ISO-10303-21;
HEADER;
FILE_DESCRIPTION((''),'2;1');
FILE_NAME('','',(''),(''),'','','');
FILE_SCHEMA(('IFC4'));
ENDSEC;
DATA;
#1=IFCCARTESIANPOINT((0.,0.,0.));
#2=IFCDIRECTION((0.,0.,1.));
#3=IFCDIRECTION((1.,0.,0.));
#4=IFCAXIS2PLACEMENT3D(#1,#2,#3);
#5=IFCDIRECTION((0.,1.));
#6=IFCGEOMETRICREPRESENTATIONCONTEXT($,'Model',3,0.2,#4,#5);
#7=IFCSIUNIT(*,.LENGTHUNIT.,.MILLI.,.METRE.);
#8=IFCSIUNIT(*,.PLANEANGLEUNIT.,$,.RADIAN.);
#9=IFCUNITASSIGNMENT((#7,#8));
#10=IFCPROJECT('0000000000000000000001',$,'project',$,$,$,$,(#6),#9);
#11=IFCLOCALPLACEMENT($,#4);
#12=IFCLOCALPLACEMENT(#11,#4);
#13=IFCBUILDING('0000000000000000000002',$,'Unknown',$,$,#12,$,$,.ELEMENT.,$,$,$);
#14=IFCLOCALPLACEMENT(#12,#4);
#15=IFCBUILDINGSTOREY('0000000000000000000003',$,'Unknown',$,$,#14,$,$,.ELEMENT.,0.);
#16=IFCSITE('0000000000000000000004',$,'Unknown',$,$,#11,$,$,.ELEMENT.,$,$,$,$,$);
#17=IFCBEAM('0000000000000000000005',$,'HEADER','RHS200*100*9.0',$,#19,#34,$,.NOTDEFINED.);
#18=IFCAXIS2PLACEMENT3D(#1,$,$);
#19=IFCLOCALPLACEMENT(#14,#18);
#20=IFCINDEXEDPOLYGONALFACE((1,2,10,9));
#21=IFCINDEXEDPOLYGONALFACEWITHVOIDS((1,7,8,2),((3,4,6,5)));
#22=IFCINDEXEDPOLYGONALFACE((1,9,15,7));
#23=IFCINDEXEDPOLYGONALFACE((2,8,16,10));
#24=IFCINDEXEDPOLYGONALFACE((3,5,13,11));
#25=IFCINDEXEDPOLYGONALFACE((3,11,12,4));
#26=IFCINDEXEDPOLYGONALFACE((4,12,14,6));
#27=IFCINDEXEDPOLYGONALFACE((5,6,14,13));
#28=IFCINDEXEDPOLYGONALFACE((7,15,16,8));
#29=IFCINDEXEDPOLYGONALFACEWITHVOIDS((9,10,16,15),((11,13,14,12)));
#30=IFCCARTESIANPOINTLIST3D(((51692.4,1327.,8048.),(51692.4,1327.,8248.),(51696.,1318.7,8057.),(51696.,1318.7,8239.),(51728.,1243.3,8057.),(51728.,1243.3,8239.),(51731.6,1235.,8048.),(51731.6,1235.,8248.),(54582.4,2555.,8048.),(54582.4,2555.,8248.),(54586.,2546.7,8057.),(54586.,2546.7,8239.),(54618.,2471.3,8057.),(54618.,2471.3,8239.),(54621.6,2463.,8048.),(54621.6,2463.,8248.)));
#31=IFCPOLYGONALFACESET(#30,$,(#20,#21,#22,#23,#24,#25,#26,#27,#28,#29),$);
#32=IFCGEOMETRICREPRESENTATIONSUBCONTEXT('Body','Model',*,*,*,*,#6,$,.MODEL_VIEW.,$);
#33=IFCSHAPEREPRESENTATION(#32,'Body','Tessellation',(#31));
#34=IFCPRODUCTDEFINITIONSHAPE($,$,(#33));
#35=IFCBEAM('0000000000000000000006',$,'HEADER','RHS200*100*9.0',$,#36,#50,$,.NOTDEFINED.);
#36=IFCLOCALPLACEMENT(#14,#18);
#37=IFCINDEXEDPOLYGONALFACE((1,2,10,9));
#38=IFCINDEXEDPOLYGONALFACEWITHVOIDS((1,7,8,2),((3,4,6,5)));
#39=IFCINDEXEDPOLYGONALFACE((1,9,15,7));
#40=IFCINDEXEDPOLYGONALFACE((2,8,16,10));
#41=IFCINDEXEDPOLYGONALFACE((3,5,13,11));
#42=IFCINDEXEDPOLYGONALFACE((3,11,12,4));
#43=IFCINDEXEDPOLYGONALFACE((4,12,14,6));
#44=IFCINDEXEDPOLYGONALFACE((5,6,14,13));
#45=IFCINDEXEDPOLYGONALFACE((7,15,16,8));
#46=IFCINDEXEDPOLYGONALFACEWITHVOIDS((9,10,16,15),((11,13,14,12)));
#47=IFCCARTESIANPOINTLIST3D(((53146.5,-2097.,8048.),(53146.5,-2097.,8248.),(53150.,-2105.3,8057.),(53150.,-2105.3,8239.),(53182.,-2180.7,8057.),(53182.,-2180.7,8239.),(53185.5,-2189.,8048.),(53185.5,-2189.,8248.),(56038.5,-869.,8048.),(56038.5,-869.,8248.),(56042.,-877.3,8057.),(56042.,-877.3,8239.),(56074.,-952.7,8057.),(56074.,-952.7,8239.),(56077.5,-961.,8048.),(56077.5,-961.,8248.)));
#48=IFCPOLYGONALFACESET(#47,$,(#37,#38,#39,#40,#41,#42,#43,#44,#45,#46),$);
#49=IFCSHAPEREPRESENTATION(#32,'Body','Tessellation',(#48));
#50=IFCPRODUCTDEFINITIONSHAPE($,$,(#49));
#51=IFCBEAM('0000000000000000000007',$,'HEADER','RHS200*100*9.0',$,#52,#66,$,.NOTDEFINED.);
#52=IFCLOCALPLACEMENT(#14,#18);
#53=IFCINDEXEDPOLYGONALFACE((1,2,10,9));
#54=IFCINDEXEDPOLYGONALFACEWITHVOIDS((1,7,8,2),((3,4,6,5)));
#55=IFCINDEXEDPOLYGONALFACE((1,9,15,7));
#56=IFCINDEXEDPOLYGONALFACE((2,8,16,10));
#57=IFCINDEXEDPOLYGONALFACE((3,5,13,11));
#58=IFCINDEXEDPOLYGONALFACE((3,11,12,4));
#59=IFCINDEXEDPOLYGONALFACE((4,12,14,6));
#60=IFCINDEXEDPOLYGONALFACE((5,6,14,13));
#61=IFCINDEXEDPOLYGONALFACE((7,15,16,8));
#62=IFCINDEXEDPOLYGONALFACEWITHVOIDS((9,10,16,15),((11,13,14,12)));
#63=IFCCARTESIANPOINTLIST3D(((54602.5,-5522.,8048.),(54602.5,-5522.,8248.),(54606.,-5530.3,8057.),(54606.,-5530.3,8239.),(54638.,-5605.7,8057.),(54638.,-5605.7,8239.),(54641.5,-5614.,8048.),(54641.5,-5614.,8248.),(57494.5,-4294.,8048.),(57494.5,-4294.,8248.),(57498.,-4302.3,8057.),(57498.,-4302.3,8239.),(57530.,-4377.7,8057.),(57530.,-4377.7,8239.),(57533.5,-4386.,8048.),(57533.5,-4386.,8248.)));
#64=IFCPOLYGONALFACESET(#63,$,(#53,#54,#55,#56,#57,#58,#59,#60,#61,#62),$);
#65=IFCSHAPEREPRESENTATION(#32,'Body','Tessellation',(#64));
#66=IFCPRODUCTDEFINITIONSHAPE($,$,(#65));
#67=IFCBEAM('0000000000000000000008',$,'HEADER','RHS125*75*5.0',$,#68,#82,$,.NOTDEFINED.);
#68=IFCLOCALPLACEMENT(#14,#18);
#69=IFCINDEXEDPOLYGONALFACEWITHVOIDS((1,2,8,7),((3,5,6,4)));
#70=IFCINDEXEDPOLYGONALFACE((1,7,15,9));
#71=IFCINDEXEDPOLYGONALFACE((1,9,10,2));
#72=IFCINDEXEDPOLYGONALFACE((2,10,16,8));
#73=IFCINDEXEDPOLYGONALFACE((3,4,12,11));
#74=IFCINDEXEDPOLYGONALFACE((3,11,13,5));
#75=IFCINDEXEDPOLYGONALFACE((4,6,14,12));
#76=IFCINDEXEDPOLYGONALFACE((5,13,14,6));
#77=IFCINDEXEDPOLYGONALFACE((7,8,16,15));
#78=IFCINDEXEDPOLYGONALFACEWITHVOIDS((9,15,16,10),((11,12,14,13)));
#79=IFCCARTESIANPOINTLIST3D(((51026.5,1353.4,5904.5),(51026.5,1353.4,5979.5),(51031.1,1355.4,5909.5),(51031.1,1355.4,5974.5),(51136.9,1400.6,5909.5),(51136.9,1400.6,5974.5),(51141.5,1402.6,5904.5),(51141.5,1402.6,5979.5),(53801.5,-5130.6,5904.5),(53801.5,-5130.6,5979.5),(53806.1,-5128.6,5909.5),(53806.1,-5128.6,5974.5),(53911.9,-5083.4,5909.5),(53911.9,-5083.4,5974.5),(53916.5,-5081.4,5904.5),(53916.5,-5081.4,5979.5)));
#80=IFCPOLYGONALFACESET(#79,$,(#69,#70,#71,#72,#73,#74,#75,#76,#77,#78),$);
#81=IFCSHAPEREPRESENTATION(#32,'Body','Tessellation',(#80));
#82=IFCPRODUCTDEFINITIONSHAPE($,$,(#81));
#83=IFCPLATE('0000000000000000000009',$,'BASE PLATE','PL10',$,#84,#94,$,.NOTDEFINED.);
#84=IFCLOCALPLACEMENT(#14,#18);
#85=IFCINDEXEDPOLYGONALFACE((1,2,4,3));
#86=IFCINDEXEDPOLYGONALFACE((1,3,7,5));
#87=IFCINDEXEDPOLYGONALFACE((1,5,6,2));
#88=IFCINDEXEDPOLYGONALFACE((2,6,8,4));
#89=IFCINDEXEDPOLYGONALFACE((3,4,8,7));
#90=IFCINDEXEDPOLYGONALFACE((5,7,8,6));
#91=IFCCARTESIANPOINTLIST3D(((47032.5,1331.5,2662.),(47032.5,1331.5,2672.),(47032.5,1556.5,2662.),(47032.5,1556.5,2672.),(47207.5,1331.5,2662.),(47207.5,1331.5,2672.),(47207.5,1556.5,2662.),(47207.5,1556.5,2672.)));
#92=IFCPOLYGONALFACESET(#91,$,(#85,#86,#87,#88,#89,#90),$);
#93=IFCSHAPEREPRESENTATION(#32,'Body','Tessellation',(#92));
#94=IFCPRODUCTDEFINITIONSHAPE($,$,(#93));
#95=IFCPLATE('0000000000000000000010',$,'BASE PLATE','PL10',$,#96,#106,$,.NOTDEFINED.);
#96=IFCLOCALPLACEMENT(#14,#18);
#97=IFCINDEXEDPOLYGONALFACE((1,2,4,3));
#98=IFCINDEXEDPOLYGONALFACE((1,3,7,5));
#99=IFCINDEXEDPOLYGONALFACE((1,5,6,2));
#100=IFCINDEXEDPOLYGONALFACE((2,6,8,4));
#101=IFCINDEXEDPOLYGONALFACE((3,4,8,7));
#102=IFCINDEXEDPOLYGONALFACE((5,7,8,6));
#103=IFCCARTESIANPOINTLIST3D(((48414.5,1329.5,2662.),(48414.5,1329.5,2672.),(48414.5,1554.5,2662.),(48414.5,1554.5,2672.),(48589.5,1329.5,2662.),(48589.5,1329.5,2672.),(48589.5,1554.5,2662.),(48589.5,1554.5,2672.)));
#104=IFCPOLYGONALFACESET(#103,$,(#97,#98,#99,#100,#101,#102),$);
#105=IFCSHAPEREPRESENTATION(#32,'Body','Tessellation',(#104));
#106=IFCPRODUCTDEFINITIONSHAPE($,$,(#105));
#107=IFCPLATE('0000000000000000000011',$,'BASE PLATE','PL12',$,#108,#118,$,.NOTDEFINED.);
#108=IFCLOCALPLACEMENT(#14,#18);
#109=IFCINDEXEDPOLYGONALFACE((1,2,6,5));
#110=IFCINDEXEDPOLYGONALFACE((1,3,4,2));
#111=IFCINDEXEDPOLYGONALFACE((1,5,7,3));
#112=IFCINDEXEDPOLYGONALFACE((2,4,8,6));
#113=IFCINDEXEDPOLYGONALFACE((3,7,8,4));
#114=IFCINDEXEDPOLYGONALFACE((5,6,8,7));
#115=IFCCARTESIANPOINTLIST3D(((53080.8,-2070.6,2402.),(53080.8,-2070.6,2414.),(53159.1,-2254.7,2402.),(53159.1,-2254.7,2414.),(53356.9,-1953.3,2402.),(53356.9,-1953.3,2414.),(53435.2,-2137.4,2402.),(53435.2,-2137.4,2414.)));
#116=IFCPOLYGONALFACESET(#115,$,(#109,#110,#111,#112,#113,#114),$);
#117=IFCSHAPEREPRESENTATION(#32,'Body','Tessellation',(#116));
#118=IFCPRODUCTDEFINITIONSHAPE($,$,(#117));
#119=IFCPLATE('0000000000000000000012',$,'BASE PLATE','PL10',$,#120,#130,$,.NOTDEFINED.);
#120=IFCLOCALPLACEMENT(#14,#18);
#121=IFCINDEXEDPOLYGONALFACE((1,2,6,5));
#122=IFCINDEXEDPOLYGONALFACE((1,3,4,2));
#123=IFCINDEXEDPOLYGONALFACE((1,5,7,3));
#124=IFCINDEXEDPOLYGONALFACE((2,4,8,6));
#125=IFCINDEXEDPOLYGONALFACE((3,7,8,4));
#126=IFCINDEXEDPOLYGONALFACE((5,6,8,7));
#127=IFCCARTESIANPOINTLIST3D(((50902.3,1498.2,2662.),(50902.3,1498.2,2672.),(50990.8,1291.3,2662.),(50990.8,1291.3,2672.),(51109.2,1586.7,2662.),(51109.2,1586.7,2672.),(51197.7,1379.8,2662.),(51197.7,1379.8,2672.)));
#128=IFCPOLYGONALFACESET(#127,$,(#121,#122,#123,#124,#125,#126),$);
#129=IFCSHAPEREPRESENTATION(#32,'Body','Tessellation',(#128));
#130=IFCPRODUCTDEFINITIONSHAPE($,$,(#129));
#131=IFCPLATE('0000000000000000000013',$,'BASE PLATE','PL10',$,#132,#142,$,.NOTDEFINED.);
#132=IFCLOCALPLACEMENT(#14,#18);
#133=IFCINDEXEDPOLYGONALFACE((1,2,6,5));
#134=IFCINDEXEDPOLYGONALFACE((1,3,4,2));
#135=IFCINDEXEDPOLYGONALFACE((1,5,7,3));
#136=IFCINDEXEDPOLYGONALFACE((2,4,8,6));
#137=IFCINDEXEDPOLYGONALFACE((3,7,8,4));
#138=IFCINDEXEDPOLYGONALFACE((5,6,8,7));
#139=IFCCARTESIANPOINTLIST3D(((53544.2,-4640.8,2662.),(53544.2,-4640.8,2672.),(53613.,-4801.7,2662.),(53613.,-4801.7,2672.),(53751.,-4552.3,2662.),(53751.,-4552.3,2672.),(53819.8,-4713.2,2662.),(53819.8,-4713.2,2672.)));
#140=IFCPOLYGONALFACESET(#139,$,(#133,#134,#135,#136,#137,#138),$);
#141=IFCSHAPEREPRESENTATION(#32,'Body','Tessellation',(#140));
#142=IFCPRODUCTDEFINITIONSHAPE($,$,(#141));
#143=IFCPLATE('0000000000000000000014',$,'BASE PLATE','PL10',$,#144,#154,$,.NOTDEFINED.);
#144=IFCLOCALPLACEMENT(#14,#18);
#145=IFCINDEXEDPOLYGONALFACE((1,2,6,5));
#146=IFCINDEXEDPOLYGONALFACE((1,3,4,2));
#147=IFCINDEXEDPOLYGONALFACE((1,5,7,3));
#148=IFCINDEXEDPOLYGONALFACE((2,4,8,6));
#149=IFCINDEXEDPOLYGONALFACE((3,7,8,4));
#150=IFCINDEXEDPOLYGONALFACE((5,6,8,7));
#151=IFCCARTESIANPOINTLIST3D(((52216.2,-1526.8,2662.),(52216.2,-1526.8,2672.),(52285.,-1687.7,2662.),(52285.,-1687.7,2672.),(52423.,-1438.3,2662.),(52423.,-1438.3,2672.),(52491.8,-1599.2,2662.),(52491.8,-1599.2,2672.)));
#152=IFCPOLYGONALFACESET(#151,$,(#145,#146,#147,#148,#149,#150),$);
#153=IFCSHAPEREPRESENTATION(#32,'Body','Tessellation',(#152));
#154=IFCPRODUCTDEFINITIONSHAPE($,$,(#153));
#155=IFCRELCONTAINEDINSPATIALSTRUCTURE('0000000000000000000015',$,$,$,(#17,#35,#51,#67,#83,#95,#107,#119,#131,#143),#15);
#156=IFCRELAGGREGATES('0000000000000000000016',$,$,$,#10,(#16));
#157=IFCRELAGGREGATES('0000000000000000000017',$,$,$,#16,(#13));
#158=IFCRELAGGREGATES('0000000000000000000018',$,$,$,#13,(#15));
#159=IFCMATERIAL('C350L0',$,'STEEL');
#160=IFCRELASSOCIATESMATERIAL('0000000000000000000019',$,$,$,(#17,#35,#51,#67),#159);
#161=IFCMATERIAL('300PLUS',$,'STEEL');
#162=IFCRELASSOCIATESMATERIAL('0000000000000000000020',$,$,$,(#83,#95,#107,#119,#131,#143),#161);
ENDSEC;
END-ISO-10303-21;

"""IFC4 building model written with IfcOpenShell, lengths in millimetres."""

from ifc_helpers import new_model, si_unit, direction, frame, origin_with_axes, place, context, subcontext, project, spatial, line, indexed_curve, outline, extrude, material, element, save


model = new_model("IFC4")

# Units and contexts
model_context = context("Model", 3, precision=0.2, world=origin_with_axes(), true_north=direction((0.0, 1.0)))
body_context = subcontext(model_context, "Body", "Model", "MODEL_VIEW")
ifc_project = project(units=[si_unit("LENGTHUNIT", "METRE", prefix="MILLI"), si_unit("PLANEANGLEUNIT", "RADIAN")], contexts=[model_context])

# Site, building, storey
site_placement = place(None, origin_with_axes())
site = spatial("IfcSite", under=ifc_project, at=site_placement, Name="Unknown", CompositionType="ELEMENT")
building_placement = place(site_placement, origin_with_axes())
building = spatial("IfcBuilding", under=site, at=building_placement, Name="Unknown", CompositionType="ELEMENT")
storey_placement = place(building_placement, origin_with_axes())
storey = spatial("IfcBuildingStorey", under=building, at=storey_placement, Name="Unknown", CompositionType="ELEMENT", Elevation=0.0)

# Shared definitions
ifc_material_1 = material(Name="C350L0", Category="STEEL")

# Beams
beam_1_placement = place(storey_placement, frame((51712.0, 1281.0, 8148.0), z_axis=(0.391073, -0.92036, 0.0), x_axis=(0.92036, 0.391073, 0.0)))
element("IfcBeam", 1, at=beam_1_placement, inside=storey, material=ifc_material_1, Name="HEADER", Description="RHS200*100*9.0", PredefinedType="NOTDEFINED", context=body_context, shape_type="SolidModel", body=[
    extrude(outline(indexed_curve([(-50.0, -100.0), (50.0, -100.0), (50.0, 100.0), (-50.0, 100.0)], segments=[line(1, 2, 3, 4, 1)]), holes=[indexed_curve([(-41.0, -91.0), (-41.0, 91.0), (41.0, 91.0), (41.0, -91.0)], segments=[line(1, 2, 3, 4, 1)])]), frame((0.0, 0.0, 0.0), z_axis=(-1.0, 0.0, 0.0), x_axis=(0.0, 0.0, 1.0)), (0.0, 0.0, -1.0), 3140.1),
])
for number, where, z_axis, x_axis, name in (
    (2, (53166.0, -2143.0, 8148.0), (0.390844, -0.920457, 0.0), (0.920457, 0.390844, 0.0), "HEADER"),
    (3, (54622.0, -5568.0, 8148.0), (0.390844, -0.920457, 0.0), (0.920457, 0.390844, 0.0), "HEADER"),
):
    element("IfcBeam", number, at=place(storey_placement, frame(where, z_axis=z_axis, x_axis=x_axis)), inside=storey, material=ifc_material_1, Name=name, Description="RHS200*100*9.0", PredefinedType="NOTDEFINED", context=body_context, shape_type="SolidModel", body=[
        extrude(outline(indexed_curve([(-50.0, -100.0), (50.0, -100.0), (50.0, 100.0), (-50.0, 100.0)], segments=[line(1, 2, 3, 4, 1)]), holes=[indexed_curve([(-41.0, -91.0), (-41.0, 91.0), (41.0, 91.0), (41.0, -91.0)], segments=[line(1, 2, 3, 4, 1)])]), frame((0.0, 0.0, 0.0), z_axis=(-1.0, 0.0, 0.0), x_axis=(0.0, 0.0, 1.0)), (0.0, 0.0, -1.0), 3141.9),
    ])
beam_2_placement = place(storey_placement, frame((53859.0, -5106.0, 5942.0), z_axis=(0.0, 0.0, 1.0), x_axis=(-0.393457, 0.919343, 0.0)))
element("IfcBeam", 4, at=beam_2_placement, inside=storey, material=ifc_material_1, Name="HEADER", Description="RHS125*75*5.0", PredefinedType="NOTDEFINED", context=body_context, shape_type="SolidModel", body=[
    extrude(outline(indexed_curve([(-37.5, -62.5), (37.5, -62.5), (37.5, 62.5), (-37.5, 62.5)], segments=[line(1, 2, 3, 4, 1)]), holes=[indexed_curve([(-32.5, -57.5), (-32.5, 57.5), (32.5, 57.5), (32.5, -57.5)], segments=[line(1, 2, 3, 4, 1)])]), frame((0.0, 0.0, 0.0), z_axis=(-1.0, 0.0, 0.0), x_axis=(0.0, 0.0, 1.0)), (0.0, 0.0, -1.0), 7052.9),
])

# Plates
ifc_material_2 = material(Name="300PLUS", Category="STEEL")
for number, where, z_axis, x_axis, name in (
    (5, (47207.5, 1331.5, 2667.0), (0.0, 0.0, 1.0), (0.0, 1.0, 0.0), "BASE PLATE"),
    (6, (48589.5, 1329.5, 2667.0), (0.0, 0.0, 1.0), (0.0, 1.0, 0.0), "BASE PLATE"),
):
    element("IfcPlate", number, at=place(storey_placement, frame(where, z_axis=z_axis, x_axis=x_axis)), inside=storey, material=ifc_material_2, Name=name, Description="PL10", PredefinedType="NOTDEFINED", context=body_context, shape_type="SolidModel", body=[
        extrude(outline(indexed_curve([(0.0, 0.0), (225.0, 0.0), (225.0, 175.0), (0.0, 175.0)], segments=[line(1, 2, 3, 4, 1)])), frame((0.0, 0.0, 5.0), z_axis=(0.0, 0.0, 1.0), x_axis=(1.0, 0.0, 0.0)), (0.0, 0.0, -1.0), 10.0),
    ])
plate_1_placement = place(storey_placement, frame((53356.9, -1953.3, 2408.0), z_axis=(0.0, 0.0, 1.0), x_axis=(-0.920382, -0.391021, 0.0)))
element("IfcPlate", 7, at=plate_1_placement, inside=storey, material=ifc_material_2, Name="BASE PLATE", Description="PL12", PredefinedType="NOTDEFINED", context=body_context, shape_type="SolidModel", body=[
    extrude(outline(indexed_curve([(0.0, 0.0), (300.0, 0.0), (299.9, 200.1), (-0.1, 200.1)], segments=[line(1, 2, 3, 4, 1)])), frame((0.0, 0.0, 6.0), z_axis=(0.0, 0.0, 1.0), x_axis=(1.0, 0.0, 0.0)), (0.0, 0.0, -1.0), 12.0),
])
plate_2_placement = place(storey_placement, frame((51197.7, 1379.8, 2667.0), z_axis=(0.0, 0.0, 1.0), x_axis=(-0.393276, 0.919421, 0.0)))
element("IfcPlate", 8, at=plate_2_placement, inside=storey, material=ifc_material_2, Name="BASE PLATE", Description="PL10", PredefinedType="NOTDEFINED", context=body_context, shape_type="SolidModel", body=[
    extrude(outline(indexed_curve([(0.0, 0.0), (225.0, 0.0), (225.0, 225.0), (0.0, 225.0)], segments=[line(1, 2, 3, 4, 1)])), frame((0.0, 0.0, 5.0), z_axis=(0.0, 0.0, 1.0), x_axis=(1.0, 0.0, 0.0)), (0.0, 0.0, -1.0), 10.0),
])
for number, where, z_axis, x_axis, name in (
    (9, (53751.0, -4552.3, 2667.0), (0.0, 0.0, 1.0), (-0.919352, -0.393436, 0.0), "BASE PLATE"),
    (10, (52423.0, -1438.3, 2667.0), (0.0, 0.0, 1.0), (-0.919352, -0.393436, 0.0), "BASE PLATE"),
):
    element("IfcPlate", number, at=place(storey_placement, frame(where, z_axis=z_axis, x_axis=x_axis)), inside=storey, material=ifc_material_2, Name=name, Description="PL10", PredefinedType="NOTDEFINED", context=body_context, shape_type="SolidModel", body=[
        extrude(outline(indexed_curve([(0.0, 0.0), (224.9, 0.0), (225.0, 175.0), (0.1, 175.0)], segments=[line(1, 2, 3, 4, 1)])), frame((0.0, 0.0, 5.0), z_axis=(0.0, 0.0, 1.0), x_axis=(1.0, 0.0, 0.0)), (0.0, 0.0, -1.0), 10.0),
    ])

save(model, "model.ifc")
